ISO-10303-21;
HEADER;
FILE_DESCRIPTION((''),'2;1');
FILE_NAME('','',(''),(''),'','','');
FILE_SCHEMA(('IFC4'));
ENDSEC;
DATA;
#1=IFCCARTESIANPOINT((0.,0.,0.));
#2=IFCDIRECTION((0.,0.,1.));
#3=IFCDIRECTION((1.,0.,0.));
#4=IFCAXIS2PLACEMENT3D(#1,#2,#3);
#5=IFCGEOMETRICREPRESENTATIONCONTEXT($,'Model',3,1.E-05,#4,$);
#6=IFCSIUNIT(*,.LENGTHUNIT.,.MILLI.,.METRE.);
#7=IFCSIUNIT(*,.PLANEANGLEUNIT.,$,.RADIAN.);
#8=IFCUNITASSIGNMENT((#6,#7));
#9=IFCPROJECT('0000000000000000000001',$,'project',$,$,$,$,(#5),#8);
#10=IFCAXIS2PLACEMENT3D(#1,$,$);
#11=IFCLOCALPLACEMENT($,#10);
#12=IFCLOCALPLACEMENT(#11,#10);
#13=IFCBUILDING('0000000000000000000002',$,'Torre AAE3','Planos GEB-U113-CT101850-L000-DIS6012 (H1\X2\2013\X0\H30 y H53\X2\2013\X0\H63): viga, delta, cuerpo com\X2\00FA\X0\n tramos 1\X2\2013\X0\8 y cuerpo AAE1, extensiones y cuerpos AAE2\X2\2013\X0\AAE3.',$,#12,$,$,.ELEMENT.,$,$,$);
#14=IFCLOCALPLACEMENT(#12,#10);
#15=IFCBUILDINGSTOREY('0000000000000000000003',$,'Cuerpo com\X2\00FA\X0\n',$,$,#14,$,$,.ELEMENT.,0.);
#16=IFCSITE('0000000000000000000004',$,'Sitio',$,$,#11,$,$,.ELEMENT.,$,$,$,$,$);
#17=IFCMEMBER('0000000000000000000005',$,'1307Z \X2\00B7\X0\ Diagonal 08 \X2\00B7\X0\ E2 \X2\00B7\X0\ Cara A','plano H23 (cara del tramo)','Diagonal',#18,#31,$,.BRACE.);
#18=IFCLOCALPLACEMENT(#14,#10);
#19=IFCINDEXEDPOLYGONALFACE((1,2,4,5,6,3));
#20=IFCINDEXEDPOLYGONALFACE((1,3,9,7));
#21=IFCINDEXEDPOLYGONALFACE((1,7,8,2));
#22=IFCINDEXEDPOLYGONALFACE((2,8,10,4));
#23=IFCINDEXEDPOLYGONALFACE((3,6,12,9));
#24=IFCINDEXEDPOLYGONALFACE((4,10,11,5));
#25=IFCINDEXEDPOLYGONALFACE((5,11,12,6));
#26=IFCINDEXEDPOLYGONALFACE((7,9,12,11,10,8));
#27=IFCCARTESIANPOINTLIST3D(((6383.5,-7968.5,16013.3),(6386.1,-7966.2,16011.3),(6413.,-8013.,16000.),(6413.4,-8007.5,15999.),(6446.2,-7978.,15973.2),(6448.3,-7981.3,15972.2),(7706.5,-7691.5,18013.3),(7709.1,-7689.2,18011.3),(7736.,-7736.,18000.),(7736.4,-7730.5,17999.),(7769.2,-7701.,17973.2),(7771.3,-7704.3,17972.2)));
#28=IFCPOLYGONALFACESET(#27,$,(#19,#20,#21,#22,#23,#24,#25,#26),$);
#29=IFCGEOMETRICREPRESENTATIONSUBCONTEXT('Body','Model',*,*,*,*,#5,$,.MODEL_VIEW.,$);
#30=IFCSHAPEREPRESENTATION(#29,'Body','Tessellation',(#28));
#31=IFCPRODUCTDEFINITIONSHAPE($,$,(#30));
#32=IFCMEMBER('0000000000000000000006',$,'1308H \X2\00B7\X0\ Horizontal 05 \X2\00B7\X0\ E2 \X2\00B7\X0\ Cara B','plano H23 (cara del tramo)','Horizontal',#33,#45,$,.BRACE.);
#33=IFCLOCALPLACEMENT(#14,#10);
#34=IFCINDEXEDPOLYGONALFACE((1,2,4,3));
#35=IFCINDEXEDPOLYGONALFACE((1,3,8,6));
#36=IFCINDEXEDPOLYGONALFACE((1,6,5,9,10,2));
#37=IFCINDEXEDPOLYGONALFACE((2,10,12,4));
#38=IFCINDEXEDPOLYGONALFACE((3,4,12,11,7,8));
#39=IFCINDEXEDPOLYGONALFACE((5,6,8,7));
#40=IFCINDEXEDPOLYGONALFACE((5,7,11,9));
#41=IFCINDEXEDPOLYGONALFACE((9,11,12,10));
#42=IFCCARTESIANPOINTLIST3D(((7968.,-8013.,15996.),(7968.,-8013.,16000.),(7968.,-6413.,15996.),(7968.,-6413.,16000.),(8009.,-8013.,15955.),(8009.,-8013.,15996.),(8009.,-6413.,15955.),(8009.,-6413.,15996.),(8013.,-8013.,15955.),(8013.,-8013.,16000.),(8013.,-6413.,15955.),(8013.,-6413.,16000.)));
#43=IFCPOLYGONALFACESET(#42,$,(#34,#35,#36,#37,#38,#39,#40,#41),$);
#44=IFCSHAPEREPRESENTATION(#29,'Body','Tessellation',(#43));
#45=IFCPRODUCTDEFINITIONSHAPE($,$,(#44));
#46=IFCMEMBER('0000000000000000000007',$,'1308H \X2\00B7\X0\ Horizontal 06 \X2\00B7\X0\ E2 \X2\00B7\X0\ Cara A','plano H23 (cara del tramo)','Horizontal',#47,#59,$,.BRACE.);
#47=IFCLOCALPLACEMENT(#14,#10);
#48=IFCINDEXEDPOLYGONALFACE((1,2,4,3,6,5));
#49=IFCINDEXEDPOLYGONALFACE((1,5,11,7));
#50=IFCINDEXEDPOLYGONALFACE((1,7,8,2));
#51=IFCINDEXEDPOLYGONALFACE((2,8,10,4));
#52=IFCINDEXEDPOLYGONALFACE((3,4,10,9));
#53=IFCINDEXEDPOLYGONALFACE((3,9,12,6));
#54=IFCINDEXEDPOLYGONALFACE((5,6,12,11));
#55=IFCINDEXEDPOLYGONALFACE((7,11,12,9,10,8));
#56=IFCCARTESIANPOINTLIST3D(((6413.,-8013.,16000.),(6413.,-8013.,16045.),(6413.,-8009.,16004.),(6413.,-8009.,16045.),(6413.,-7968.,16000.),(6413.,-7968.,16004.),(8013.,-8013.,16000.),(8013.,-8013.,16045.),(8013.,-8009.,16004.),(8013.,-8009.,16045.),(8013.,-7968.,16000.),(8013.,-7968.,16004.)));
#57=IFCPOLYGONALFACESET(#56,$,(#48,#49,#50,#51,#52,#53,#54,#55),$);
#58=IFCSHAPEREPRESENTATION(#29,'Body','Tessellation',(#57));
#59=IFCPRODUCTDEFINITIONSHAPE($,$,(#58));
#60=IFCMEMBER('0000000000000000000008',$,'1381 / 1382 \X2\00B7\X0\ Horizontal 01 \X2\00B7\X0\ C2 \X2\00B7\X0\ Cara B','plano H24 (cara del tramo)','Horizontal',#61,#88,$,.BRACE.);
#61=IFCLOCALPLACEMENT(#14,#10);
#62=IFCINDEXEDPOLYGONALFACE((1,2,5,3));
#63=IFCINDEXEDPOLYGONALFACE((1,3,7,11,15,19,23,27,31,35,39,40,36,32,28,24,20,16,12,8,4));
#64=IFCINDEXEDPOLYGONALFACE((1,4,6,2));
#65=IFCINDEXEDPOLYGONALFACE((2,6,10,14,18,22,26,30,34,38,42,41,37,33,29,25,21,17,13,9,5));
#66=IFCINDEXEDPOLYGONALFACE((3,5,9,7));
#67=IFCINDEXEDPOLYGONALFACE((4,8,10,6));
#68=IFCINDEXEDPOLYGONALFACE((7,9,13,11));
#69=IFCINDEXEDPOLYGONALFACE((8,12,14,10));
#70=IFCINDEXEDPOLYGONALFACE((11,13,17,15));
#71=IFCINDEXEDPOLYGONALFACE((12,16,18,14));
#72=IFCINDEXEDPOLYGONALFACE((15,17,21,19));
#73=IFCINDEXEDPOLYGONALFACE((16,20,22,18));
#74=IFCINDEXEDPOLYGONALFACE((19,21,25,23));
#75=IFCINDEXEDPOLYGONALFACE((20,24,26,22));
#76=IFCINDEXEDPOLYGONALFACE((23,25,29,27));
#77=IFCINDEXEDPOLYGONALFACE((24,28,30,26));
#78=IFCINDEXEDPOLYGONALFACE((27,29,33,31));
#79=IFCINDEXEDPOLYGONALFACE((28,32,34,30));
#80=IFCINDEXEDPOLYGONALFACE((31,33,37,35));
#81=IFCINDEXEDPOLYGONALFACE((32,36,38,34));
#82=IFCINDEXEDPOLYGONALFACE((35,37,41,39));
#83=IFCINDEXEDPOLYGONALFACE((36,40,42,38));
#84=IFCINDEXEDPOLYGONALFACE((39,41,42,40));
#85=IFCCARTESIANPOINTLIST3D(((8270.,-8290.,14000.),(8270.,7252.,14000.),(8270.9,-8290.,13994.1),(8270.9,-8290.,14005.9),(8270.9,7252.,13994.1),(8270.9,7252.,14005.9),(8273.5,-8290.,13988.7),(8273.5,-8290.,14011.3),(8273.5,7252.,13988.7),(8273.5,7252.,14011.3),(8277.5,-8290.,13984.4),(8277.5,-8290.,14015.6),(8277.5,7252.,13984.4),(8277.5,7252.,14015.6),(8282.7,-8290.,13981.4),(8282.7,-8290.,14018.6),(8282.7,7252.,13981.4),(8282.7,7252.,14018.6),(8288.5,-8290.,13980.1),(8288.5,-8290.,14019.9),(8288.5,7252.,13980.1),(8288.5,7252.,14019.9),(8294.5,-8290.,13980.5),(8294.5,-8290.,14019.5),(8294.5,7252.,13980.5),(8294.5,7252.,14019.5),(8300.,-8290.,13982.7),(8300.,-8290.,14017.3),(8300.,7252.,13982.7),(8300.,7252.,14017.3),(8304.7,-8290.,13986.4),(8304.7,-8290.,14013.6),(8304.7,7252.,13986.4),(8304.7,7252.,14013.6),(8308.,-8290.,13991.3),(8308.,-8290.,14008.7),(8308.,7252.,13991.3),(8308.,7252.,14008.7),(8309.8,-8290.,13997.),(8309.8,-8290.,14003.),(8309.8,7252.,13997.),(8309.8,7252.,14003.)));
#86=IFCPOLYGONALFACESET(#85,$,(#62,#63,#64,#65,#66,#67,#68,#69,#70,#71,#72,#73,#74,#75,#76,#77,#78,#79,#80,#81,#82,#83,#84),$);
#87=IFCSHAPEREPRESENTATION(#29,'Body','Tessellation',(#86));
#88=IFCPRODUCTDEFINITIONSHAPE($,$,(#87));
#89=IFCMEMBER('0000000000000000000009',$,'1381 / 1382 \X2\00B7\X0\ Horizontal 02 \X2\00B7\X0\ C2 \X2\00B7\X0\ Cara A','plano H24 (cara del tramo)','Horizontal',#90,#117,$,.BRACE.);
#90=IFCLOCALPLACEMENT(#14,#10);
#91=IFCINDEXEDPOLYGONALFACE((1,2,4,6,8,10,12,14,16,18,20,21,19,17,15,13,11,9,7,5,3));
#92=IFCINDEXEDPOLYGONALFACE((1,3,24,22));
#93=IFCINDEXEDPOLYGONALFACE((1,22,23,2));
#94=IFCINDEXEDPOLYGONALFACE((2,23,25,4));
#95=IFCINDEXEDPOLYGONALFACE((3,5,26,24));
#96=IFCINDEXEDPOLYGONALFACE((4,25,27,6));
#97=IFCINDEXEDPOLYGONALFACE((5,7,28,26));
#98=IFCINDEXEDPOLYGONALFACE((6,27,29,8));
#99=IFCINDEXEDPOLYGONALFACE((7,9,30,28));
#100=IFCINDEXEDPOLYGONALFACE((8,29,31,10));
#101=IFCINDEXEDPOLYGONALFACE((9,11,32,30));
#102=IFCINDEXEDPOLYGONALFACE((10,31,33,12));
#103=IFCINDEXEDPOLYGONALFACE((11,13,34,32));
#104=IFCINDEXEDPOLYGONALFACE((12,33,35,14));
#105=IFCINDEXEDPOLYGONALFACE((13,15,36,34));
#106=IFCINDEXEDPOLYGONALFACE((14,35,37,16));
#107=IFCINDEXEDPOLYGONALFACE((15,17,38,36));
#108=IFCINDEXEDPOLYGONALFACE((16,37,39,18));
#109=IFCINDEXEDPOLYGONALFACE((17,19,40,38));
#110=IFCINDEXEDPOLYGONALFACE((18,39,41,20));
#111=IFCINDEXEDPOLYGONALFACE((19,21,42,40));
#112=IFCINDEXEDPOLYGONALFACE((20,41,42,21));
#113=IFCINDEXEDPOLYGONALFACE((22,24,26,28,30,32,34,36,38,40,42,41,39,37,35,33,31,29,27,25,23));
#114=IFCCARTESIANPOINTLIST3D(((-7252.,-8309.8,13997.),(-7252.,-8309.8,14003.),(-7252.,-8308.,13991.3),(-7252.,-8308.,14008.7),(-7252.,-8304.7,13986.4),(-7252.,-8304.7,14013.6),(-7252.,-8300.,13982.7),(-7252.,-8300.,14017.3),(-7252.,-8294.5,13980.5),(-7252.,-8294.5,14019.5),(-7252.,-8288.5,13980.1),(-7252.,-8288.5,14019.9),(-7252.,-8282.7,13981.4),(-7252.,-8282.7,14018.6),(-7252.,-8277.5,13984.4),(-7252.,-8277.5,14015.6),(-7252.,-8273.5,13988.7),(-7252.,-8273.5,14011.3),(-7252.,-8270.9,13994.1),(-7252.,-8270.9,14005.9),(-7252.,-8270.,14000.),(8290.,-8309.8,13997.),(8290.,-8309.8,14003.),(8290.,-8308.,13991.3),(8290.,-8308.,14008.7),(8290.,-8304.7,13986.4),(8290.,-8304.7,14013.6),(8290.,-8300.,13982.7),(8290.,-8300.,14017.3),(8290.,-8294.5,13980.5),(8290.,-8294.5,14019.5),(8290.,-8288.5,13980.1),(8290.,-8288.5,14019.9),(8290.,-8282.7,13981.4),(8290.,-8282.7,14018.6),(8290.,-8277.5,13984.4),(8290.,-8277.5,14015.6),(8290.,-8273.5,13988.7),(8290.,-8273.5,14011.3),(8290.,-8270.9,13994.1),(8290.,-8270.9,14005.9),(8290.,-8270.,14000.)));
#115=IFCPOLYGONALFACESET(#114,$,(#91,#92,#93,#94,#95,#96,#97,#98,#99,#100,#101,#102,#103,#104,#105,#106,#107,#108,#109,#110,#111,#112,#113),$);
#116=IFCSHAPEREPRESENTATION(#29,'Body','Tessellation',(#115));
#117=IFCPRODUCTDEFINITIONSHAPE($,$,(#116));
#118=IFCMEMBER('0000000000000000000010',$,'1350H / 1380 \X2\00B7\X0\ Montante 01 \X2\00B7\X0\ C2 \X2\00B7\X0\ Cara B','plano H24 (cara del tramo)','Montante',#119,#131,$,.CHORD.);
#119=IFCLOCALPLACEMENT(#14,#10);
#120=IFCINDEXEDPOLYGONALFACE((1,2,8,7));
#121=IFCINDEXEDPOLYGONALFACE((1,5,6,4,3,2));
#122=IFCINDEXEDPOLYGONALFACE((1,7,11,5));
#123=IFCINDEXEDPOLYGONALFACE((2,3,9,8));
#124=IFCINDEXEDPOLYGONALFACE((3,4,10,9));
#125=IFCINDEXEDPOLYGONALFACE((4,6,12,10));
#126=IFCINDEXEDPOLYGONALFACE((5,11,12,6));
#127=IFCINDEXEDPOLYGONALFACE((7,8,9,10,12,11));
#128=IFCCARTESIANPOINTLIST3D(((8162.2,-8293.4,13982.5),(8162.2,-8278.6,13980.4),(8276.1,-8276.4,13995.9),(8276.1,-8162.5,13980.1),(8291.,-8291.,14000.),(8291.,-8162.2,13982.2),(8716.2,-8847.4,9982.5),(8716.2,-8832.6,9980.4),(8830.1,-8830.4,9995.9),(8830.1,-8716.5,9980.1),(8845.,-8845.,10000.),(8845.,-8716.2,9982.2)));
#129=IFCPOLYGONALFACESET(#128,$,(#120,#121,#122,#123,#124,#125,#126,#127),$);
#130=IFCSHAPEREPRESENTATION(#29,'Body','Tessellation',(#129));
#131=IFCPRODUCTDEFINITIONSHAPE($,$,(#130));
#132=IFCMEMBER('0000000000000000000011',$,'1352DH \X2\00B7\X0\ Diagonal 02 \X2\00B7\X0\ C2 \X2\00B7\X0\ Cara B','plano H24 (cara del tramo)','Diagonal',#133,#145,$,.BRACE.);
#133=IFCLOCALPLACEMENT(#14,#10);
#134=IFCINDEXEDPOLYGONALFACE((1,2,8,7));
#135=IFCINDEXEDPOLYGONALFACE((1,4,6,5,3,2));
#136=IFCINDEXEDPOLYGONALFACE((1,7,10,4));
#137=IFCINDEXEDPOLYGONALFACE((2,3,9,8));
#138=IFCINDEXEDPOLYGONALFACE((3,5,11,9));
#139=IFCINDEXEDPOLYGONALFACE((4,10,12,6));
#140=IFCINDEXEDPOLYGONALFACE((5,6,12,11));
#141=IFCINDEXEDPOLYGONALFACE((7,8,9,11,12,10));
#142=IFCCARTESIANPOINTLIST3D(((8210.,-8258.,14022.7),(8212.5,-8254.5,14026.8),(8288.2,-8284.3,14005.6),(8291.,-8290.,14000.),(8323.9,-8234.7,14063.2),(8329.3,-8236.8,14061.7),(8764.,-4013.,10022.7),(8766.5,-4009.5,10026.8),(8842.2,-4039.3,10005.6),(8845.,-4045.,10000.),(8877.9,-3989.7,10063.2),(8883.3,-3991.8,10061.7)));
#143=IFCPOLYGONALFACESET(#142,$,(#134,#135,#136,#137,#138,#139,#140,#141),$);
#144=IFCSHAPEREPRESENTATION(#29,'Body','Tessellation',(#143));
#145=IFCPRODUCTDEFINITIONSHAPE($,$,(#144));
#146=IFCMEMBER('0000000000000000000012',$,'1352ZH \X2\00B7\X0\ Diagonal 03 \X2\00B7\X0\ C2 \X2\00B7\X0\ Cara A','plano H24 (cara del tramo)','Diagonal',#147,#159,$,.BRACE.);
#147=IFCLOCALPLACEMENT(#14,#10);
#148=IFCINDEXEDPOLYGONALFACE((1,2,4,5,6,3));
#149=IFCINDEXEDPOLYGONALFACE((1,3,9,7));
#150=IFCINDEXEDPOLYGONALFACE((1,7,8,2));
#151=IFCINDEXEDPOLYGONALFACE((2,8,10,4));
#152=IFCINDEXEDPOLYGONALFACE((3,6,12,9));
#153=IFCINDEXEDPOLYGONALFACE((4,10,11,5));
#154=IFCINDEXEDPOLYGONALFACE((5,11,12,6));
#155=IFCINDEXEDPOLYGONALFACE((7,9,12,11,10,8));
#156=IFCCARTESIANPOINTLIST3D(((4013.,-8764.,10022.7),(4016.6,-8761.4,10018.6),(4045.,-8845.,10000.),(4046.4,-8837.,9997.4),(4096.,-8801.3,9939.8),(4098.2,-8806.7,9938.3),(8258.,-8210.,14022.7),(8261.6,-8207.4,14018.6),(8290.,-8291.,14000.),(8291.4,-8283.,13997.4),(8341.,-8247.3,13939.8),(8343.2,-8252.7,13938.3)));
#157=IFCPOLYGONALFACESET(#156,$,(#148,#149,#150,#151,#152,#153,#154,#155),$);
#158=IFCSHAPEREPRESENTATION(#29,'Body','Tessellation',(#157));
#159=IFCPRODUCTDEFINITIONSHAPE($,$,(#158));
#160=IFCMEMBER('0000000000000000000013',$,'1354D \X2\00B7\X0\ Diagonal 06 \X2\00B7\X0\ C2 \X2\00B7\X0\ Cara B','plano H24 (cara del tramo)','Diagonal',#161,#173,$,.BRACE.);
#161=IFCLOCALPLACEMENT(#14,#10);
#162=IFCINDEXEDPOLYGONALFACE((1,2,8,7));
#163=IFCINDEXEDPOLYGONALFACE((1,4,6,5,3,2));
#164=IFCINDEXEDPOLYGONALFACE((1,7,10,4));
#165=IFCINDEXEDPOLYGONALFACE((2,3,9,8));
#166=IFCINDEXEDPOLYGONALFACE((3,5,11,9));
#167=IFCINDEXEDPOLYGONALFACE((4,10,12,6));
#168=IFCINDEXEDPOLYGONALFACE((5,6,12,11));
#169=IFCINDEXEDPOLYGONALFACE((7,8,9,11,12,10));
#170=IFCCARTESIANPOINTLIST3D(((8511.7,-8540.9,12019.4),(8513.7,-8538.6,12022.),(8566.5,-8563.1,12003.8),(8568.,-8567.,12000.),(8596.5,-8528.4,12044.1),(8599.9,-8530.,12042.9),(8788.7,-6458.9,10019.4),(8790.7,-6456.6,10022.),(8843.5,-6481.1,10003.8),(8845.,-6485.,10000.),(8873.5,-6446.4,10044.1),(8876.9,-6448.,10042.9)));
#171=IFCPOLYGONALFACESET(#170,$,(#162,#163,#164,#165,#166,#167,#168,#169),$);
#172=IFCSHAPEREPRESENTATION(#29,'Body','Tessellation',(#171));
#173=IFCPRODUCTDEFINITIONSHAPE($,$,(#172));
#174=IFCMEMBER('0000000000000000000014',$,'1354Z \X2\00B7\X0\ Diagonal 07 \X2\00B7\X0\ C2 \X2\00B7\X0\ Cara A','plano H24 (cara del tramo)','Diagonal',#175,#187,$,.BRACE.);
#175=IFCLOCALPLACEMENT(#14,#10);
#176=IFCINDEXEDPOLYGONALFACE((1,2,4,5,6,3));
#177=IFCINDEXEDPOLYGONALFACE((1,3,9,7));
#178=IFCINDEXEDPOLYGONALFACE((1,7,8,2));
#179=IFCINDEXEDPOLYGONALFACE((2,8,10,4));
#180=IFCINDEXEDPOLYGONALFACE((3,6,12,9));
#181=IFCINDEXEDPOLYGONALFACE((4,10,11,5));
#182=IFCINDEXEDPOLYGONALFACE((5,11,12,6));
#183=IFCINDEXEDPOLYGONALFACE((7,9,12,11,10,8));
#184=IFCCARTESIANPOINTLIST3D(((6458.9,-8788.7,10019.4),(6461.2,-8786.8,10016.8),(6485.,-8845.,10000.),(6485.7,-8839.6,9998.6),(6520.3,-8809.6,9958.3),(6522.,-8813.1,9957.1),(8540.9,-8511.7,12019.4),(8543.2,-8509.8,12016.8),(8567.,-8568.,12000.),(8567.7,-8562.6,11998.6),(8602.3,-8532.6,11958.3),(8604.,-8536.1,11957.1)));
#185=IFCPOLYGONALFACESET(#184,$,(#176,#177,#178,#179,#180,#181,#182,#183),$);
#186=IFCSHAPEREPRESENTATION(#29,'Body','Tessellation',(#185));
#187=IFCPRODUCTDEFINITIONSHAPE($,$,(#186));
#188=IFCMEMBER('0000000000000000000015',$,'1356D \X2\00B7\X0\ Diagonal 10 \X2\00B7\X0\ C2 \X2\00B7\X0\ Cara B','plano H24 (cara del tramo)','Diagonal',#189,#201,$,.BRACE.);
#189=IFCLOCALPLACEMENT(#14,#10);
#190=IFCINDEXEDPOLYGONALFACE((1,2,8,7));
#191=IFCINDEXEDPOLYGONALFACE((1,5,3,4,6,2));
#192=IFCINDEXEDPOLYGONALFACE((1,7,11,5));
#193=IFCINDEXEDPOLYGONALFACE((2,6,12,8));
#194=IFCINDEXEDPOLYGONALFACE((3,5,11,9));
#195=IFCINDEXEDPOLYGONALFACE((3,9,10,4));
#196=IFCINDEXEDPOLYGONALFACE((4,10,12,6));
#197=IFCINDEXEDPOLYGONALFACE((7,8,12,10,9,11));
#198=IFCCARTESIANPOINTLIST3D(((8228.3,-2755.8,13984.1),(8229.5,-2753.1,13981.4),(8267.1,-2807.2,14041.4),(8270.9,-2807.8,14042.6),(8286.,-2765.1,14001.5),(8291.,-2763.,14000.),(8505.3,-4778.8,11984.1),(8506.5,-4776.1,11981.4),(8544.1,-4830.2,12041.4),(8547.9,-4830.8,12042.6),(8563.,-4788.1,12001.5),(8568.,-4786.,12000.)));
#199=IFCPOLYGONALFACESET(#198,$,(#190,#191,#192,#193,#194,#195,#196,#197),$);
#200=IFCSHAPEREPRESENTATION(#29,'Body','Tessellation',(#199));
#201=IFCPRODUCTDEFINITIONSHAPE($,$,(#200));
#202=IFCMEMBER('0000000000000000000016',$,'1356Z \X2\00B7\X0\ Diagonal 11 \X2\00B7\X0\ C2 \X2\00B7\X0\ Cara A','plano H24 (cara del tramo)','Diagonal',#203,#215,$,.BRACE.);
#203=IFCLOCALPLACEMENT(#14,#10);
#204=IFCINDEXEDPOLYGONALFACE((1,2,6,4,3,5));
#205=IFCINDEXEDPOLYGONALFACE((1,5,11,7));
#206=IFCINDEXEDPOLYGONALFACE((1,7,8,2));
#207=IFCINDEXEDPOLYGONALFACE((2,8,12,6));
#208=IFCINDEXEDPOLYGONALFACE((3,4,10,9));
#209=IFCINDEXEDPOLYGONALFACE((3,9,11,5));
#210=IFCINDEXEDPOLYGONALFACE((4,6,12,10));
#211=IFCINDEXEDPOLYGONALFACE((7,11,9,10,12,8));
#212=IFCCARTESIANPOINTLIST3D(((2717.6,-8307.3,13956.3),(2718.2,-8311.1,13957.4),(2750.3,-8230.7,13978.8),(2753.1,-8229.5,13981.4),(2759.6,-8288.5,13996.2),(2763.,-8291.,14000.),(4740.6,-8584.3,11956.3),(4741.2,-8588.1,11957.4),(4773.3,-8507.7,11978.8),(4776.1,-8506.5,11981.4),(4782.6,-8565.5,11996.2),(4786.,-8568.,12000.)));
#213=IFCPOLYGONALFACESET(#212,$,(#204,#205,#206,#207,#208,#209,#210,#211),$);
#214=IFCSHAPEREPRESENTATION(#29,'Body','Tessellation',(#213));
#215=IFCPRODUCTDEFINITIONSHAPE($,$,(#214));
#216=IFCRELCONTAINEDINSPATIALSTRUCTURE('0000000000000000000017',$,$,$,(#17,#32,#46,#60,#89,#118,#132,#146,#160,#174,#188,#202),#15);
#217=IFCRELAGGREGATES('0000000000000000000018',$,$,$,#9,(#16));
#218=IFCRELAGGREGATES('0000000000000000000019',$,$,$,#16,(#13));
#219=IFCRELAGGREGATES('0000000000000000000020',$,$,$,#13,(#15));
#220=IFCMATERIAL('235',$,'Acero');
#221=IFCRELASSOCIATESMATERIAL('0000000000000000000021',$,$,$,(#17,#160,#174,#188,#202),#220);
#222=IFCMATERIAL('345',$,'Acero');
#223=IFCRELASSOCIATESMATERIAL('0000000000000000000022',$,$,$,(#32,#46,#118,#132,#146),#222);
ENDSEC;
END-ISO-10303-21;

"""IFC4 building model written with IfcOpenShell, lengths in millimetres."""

from ifc_helpers import new_model, si_unit, frame, frame_2d, origin, origin_with_axes, place, context, subcontext, project, spatial, circle, l_section, extrude, material, element, save


model = new_model("IFC4")

# Units and contexts
model_context = context("Model", 3, precision=1e-05, world=origin_with_axes())
body_context = subcontext(model_context, "Body", "Model", "MODEL_VIEW")
ifc_project = project(units=[si_unit("LENGTHUNIT", "METRE", prefix="MILLI"), si_unit("PLANEANGLEUNIT", "RADIAN")], contexts=[model_context])

# Site, building, storey
site_placement = place(None, origin())
site = spatial("IfcSite", under=ifc_project, at=site_placement, Name="Sitio", CompositionType="ELEMENT")
building_placement = place(site_placement, origin())
building = spatial("IfcBuilding", under=site, at=building_placement, Name="Torre AAE3", Description="Planos GEB-U113-CT101850-L000-DIS6012 (H1–H30 y H53–H63): viga, delta, cuerpo común tramos 1–8 y cuerpo AAE1, extensiones y cuerpos AAE2–AAE3.", CompositionType="ELEMENT")
storey_placement = place(building_placement, origin())
storey = spatial("IfcBuildingStorey", under=building, at=storey_placement, Name="Cuerpo común", CompositionType="ELEMENT", Elevation=0.0)

# Members
ifc_material_1 = material(Name="345", Category="Acero")
ifc_material_2 = material(Name="235", Category="Acero")
for number, where, z_axis, x_axis, name in (
    (1, (7736.0, -7736.0, 18000.0), (-0.548069, -0.114751, -0.828524), (-0.535928, 0.808683, 0.242514), "1307Z · Diagonal 08 · E2 · Cara A"),
):
    element("IfcMember", number, at=place(storey_placement, frame(where, z_axis=z_axis, x_axis=x_axis)), inside=storey, material=ifc_material_2, Name=name, Description="plano H23 (cara del tramo)", ObjectType="Diagonal", PredefinedType="BRACE", context=body_context, shape_type="SweptSolid", body=[
        extrude(l_section(Depth=55.0, Width=55.0, Thickness=4.0, at=frame_2d((27.5, 27.5))), None, (0.0, 0.0, 1.0), 2413.9),
    ])
for number, where, z_axis, x_axis, name in (
    (2, (8013.0, -6413.0, 16000.0), (0.0, -1.0, 0.0), (-1.0, 0.0, 0.0), "1308H · Horizontal 05 · E2 · Cara B"),
    (3, (6413.0, -8013.0, 16000.0), (1.0, 0.0, 0.0), (0.0, 1.0, 0.0), "1308H · Horizontal 06 · E2 · Cara A"),
):
    element("IfcMember", number, at=place(storey_placement, frame(where, z_axis=z_axis, x_axis=x_axis)), inside=storey, material=ifc_material_1, Name=name, Description="plano H23 (cara del tramo)", ObjectType="Horizontal", PredefinedType="BRACE", context=body_context, shape_type="SweptSolid", body=[
        extrude(l_section(Depth=45.0, Width=45.0, Thickness=4.0, at=frame_2d((22.5, 22.5))), None, (0.0, 0.0, 1.0), 1600.0),
    ])
for number, where, z_axis, x_axis, name in (
    (4, (8290.0, -8290.0, 14000.0), (0.0, 1.0, 0.0), (-1.0, 0.0, 0.0), "1381 / 1382 · Horizontal 01 · C2 · Cara B"),
    (5, (8290.0, -8290.0, 14000.0), (-1.0, 0.0, 0.0), (0.0, 1.0, 0.0), "1381 / 1382 · Horizontal 02 · C2 · Cara A"),
):
    element("IfcMember", number, at=place(storey_placement, frame(where, z_axis=z_axis, x_axis=x_axis)), inside=storey, Name=name, Description="plano H24 (cara del tramo)", ObjectType="Horizontal", PredefinedType="BRACE", context=body_context, shape_type="SweptSolid", body=[
        extrude(circle(Radius=20.0), None, (0.0, 0.0, 1.0), 15542.0),
    ])
member_1_placement = place(storey_placement, frame((8291.0, -8291.0, 14000.0), z_axis=(0.135917, -0.135917, -0.981353), x_axis=(-0.99072, -0.018647, -0.134632)))
element("IfcMember", 6, at=member_1_placement, inside=storey, material=ifc_material_1, Name="1350H / 1380 · Montante 01 · C2 · Cara B", Description="plano H24 (cara del tramo)", ObjectType="Montante", PredefinedType="CHORD", context=body_context, shape_type="SweptSolid", body=[
    extrude(l_section(Depth=130.0, Width=130.0, Thickness=15.0, at=frame_2d((65.0, 65.0))), None, (0.0, 0.0, 1.0), 4076.0),
])
for number, where, z_axis, x_axis, name in (
    (7, (8291.0, -8290.0, 14000.0), (0.094557, 0.724536, -0.68272), (-0.900146, 0.355138, 0.25222), "1352DH · Diagonal 02 · C2 · Cara B"),
    (8, (8290.0, -8291.0, 14000.0), (-0.724536, -0.094557, -0.68272), (-0.355138, 0.900146, 0.25222), "1352ZH · Diagonal 03 · C2 · Cara A"),
):
    element("IfcMember", number, at=place(storey_placement, frame(where, z_axis=z_axis, x_axis=x_axis)), inside=storey, material=ifc_material_1, Name=name, Description="plano H24 (cara del tramo)", ObjectType="Diagonal", PredefinedType="BRACE", context=body_context, shape_type="SweptSolid", body=[
        extrude(l_section(Depth=90.0, Width=90.0, Thickness=6.0, at=frame_2d((45.0, 45.0))), None, (0.0, 0.0, 1.0), 5858.9),
    ])
for number, where, z_axis, x_axis, name in (
    (9, (8568.0, -8567.0, 12000.0), (0.095509, 0.717869, -0.689596), (-0.865687, 0.401881, 0.29846), "1354D · Diagonal 06 · C2 · Cara B"),
    (10, (8567.0, -8568.0, 12000.0), (-0.717869, -0.095509, -0.689596), (-0.401881, 0.865687, 0.29846), "1354Z · Diagonal 07 · C2 · Cara A"),
):
    element("IfcMember", number, at=place(storey_placement, frame(where, z_axis=z_axis, x_axis=x_axis)), inside=storey, material=ifc_material_2, Name=name, Description="plano H24 (cara del tramo)", ObjectType="Diagonal", PredefinedType="BRACE", context=body_context, shape_type="SweptSolid", body=[
        extrude(l_section(Depth=65.0, Width=65.0, Thickness=4.0, at=frame_2d((32.5, 32.5))), None, (0.0, 0.0, 1.0), 2900.3),
    ])
for number, where, z_axis, x_axis, name in (
    (11, (8568.0, -4786.0, 12000.0), (-0.096914, 0.70779, 0.699743), (-0.946162, 0.152643, -0.285442), "1356D · Diagonal 10 · C2 · Cara B"),
    (12, (4786.0, -8568.0, 12000.0), (-0.70779, 0.096914, 0.699743), (-0.152643, 0.946162, -0.285442), "1356Z · Diagonal 11 · C2 · Cara A"),
):
    element("IfcMember", number, at=place(storey_placement, frame(where, z_axis=z_axis, x_axis=x_axis)), inside=storey, material=ifc_material_2, Name=name, Description="plano H24 (cara del tramo)", ObjectType="Diagonal", PredefinedType="BRACE", context=body_context, shape_type="SweptSolid", body=[
        extrude(l_section(Depth=65.0, Width=65.0, Thickness=4.0, at=frame_2d((32.5, 32.5))), None, (0.0, 0.0, 1.0), 2858.2),
    ])

save(model, "model.ifc")
